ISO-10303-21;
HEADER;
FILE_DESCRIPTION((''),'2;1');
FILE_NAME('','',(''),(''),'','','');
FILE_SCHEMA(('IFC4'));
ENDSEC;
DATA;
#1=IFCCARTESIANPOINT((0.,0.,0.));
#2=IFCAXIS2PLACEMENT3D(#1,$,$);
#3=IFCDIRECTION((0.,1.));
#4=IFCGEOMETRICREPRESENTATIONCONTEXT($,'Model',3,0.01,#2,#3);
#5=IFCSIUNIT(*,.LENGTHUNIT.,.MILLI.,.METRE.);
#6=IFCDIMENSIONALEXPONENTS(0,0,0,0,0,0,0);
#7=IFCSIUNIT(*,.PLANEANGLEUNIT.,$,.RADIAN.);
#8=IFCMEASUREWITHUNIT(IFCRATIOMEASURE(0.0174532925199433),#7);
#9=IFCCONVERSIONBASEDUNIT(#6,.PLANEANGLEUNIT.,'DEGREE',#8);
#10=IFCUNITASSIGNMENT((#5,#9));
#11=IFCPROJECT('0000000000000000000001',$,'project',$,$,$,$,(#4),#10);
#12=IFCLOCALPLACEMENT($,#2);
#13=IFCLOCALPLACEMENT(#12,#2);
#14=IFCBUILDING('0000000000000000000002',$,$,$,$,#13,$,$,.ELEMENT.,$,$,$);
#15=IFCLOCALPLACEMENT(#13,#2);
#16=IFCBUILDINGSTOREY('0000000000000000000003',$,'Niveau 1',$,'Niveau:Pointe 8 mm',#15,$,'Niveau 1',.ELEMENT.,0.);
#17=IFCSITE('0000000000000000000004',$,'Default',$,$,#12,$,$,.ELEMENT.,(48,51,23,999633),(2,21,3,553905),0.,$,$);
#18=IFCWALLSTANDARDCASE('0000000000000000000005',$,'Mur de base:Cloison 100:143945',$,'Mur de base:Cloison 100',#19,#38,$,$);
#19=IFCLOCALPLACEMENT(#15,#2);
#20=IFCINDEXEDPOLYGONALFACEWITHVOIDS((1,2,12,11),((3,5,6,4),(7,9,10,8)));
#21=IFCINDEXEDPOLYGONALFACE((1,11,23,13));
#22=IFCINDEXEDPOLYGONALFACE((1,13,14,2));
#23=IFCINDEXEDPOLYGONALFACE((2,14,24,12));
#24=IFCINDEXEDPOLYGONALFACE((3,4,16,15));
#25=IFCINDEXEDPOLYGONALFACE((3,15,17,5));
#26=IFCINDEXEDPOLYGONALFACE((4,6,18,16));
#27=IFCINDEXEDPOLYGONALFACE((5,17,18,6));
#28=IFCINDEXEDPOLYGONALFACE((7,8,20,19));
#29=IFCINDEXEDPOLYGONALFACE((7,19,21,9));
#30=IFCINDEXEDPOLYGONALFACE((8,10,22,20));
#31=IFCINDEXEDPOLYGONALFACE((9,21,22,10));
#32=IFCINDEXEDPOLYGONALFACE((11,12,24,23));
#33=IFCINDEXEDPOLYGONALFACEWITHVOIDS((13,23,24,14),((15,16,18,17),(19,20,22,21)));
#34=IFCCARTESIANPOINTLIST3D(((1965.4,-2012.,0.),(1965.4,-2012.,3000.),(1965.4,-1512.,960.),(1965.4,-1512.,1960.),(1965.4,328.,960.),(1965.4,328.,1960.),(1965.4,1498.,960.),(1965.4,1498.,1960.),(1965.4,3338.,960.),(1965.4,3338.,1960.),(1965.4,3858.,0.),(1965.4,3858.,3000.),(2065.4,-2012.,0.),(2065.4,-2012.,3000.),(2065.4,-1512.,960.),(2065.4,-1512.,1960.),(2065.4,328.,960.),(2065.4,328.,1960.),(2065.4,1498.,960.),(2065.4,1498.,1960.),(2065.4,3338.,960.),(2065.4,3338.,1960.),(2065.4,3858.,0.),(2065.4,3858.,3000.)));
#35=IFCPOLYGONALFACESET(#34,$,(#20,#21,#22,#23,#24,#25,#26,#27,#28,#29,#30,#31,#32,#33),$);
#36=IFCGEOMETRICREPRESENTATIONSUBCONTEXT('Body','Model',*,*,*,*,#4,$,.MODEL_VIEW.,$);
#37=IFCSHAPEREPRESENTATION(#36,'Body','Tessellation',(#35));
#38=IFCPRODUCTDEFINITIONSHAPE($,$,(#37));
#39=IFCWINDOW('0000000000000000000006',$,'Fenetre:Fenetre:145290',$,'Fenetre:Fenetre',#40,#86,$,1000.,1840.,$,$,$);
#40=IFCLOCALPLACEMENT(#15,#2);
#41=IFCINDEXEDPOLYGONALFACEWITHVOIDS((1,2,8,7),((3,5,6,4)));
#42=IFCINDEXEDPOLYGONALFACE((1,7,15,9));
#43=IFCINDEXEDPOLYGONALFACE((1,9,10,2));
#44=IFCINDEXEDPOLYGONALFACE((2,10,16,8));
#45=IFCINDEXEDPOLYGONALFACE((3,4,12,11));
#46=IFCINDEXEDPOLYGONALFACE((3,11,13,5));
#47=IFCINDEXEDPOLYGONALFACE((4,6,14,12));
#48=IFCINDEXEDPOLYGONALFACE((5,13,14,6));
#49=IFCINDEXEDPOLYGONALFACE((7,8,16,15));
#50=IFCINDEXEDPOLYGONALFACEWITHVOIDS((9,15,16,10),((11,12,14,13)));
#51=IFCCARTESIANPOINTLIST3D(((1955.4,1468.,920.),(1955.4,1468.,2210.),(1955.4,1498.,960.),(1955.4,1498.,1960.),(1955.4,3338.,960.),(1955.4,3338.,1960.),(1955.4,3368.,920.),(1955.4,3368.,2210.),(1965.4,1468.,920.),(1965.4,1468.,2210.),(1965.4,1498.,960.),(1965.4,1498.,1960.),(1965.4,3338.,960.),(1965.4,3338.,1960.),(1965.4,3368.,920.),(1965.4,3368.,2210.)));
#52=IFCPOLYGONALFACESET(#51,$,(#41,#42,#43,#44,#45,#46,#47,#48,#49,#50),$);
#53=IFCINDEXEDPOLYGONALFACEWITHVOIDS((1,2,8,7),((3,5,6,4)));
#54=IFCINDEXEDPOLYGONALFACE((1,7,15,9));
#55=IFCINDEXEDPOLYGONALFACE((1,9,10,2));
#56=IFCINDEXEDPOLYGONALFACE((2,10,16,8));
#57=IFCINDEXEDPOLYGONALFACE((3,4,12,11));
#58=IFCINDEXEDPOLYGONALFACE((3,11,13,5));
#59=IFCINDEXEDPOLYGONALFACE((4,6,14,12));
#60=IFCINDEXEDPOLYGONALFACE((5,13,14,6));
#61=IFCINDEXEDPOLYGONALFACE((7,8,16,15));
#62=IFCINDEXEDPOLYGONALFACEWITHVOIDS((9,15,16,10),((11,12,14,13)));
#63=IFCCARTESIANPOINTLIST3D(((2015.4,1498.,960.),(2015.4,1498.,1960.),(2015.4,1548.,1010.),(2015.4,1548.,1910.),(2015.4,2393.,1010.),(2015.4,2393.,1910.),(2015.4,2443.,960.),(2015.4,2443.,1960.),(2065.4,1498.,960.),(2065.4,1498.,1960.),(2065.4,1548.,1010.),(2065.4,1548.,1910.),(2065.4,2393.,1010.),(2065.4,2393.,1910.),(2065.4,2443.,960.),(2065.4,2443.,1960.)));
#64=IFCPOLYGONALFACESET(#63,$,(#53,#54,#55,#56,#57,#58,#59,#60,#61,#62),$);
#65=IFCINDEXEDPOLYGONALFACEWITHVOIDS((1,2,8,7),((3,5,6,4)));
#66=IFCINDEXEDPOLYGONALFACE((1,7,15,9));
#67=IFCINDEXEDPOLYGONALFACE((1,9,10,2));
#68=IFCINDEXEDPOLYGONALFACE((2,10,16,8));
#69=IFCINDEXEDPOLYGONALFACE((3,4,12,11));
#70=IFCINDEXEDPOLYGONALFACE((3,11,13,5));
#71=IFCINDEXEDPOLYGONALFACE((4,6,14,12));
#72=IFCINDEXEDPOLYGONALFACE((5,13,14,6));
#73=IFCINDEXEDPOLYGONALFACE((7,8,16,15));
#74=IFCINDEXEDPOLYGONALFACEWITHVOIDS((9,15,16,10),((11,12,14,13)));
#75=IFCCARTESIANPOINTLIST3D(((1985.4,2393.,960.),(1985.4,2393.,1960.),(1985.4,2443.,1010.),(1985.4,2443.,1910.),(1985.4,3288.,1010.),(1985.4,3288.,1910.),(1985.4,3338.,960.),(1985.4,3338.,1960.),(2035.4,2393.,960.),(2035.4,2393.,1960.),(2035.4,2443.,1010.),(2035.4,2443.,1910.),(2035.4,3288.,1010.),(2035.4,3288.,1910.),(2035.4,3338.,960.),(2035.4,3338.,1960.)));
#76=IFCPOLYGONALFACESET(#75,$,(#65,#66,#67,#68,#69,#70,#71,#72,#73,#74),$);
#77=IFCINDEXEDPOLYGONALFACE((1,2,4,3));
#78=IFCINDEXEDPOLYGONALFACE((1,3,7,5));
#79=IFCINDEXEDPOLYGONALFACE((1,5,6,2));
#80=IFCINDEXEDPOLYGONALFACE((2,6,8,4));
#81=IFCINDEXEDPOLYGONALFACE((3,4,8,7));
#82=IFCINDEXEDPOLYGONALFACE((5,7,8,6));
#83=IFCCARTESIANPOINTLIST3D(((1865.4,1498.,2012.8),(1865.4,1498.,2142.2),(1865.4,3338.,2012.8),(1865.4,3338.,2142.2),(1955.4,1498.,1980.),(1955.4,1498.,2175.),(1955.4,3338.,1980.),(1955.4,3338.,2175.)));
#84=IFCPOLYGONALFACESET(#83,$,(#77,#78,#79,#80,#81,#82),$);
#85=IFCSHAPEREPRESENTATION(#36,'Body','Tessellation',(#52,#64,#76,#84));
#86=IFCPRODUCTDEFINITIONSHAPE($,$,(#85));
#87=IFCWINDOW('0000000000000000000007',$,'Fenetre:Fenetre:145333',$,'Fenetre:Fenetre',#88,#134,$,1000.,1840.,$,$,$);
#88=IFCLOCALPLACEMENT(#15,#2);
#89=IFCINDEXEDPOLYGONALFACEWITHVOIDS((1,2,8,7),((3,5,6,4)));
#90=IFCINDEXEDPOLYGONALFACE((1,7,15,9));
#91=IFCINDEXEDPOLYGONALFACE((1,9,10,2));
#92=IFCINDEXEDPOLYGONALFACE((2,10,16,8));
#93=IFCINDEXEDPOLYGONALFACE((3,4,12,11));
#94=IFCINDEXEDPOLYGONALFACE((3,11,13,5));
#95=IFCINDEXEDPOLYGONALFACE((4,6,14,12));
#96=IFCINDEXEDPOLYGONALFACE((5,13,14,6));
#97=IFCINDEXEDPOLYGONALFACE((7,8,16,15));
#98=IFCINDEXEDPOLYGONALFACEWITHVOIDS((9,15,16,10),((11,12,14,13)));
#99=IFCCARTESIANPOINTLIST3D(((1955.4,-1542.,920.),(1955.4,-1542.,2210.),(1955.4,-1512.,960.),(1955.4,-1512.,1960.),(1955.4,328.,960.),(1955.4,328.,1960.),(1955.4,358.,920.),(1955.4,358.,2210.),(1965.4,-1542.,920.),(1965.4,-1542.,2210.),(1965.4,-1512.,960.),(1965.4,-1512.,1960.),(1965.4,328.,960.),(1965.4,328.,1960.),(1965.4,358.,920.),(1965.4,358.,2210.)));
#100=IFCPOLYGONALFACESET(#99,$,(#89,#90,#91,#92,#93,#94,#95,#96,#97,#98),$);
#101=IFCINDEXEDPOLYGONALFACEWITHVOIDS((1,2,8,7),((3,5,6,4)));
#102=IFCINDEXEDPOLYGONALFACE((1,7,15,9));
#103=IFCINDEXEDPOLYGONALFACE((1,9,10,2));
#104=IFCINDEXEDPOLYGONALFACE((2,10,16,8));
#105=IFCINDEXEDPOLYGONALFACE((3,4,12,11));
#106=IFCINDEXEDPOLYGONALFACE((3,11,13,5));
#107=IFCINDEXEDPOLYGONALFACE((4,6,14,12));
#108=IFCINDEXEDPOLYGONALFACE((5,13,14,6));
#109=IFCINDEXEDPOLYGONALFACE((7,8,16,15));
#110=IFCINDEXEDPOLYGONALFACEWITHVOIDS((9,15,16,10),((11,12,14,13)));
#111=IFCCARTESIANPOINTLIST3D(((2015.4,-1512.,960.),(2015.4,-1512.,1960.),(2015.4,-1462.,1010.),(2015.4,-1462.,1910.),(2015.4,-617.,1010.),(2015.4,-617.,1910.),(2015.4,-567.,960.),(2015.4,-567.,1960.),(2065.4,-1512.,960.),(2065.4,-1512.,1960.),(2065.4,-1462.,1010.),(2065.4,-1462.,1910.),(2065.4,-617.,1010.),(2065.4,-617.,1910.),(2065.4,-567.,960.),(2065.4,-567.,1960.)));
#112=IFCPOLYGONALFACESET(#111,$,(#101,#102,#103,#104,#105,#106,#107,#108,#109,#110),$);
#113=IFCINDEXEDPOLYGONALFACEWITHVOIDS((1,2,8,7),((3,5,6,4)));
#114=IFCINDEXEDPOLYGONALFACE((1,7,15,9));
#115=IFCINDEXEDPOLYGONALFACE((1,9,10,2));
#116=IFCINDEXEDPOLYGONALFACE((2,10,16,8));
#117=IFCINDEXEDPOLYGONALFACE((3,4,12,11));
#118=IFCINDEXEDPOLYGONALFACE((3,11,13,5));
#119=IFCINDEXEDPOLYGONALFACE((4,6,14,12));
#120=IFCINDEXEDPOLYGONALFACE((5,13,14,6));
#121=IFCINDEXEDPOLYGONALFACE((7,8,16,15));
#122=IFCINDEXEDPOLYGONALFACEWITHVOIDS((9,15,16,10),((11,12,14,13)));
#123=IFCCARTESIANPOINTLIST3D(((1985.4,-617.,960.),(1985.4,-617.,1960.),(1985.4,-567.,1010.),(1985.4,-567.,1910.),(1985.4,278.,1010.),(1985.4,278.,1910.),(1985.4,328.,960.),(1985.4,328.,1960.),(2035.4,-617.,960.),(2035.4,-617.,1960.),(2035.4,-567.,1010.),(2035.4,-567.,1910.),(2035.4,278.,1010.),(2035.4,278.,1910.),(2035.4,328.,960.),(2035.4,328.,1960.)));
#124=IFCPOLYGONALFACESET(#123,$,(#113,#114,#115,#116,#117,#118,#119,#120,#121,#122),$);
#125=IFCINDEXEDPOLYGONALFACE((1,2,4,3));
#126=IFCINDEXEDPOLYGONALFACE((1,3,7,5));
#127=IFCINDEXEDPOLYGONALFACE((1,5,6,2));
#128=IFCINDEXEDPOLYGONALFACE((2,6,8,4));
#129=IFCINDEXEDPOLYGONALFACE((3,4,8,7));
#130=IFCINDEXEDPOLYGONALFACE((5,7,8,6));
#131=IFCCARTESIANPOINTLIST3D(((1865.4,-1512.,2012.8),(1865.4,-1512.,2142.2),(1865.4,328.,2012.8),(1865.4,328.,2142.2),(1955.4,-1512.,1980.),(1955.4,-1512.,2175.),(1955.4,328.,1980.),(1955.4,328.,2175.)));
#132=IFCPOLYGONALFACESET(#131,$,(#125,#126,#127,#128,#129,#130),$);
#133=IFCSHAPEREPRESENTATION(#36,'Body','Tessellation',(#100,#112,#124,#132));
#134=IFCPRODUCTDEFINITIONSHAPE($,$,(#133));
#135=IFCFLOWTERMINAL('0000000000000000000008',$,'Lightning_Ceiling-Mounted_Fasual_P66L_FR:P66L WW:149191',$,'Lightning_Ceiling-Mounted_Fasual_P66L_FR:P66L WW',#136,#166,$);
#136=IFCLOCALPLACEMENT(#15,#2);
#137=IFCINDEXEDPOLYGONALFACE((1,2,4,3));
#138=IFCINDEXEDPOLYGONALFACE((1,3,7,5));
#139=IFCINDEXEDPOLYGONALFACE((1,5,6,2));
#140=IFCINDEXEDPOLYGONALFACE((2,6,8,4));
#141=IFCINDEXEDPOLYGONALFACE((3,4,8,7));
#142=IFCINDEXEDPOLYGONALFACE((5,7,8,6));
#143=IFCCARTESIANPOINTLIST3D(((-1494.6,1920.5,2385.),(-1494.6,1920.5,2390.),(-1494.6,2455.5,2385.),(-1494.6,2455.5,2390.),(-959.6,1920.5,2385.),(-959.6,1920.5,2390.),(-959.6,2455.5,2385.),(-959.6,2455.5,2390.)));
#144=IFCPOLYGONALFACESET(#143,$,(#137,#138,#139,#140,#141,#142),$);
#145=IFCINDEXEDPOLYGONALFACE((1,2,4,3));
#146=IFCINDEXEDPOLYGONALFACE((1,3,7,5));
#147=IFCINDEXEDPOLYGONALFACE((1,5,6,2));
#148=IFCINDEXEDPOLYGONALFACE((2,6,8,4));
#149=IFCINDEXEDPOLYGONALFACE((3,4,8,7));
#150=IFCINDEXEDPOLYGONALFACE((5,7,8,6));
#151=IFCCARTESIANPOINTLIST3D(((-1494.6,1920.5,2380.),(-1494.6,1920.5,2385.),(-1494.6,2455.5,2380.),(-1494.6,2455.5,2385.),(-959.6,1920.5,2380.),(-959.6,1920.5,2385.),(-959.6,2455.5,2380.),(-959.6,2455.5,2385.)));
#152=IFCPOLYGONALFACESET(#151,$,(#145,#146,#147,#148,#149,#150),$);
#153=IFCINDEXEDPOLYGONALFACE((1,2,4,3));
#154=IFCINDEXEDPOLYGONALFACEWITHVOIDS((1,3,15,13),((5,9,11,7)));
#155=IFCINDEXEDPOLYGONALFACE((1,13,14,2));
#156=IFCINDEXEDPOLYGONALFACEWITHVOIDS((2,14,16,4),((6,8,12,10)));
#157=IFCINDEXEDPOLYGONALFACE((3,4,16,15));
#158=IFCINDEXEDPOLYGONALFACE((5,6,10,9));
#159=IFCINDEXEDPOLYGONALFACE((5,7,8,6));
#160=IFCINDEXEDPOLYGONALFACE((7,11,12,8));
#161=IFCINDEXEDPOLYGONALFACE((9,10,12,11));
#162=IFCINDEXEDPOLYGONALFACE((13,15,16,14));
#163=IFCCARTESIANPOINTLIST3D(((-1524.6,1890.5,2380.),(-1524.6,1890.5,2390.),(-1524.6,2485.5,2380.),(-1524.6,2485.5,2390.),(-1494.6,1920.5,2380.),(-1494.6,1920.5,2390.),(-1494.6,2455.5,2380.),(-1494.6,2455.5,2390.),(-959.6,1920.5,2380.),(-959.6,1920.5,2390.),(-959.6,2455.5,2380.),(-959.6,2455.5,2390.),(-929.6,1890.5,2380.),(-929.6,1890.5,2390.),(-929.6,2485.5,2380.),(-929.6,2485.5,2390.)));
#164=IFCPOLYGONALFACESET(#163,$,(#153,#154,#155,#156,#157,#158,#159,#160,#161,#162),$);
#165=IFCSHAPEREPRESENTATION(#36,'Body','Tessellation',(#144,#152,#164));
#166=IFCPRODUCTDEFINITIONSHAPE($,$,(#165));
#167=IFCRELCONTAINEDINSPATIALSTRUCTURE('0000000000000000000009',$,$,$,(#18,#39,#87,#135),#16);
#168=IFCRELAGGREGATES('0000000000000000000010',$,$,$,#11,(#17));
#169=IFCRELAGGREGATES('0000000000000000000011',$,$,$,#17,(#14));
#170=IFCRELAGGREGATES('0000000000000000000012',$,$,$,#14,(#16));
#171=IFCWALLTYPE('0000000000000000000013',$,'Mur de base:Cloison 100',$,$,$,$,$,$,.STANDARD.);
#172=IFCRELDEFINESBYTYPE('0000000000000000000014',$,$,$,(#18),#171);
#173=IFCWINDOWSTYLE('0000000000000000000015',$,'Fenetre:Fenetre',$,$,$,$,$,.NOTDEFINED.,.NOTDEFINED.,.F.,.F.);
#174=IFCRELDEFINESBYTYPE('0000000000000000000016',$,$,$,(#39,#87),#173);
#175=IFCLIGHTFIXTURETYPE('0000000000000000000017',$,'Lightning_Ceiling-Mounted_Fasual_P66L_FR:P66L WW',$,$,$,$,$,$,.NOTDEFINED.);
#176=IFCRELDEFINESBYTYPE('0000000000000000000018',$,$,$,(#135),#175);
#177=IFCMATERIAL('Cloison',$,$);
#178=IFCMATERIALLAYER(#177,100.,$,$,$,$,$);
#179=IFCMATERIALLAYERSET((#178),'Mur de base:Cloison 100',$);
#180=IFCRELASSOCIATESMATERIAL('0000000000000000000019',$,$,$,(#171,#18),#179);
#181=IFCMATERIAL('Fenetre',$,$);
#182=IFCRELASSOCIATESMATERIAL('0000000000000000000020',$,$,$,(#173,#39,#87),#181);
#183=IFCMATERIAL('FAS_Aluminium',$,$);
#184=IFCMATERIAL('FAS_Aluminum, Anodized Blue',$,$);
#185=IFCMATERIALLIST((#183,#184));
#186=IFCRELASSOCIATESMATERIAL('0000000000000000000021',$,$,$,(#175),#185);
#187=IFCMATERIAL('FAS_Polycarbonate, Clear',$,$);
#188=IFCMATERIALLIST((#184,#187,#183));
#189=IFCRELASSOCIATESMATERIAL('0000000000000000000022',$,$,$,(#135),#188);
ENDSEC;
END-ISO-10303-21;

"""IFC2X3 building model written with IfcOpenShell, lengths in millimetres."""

from ifc_helpers import new_model, entity, si_unit, converted_unit, direction, frame, frame_2d, origin, origin_2d_with_axis, place, context, subcontext, project, spatial, polyline, rectangle, outline, extrude, source, transform, mapped, material, material_list, layer, layer_set, layer_usage, type_object, type_shapes, element, fill, save


model = new_model("IFC2X3")

# Units and contexts
model_context = context("Model", 3, precision=0.01, world=origin(), true_north=direction((0.0, 1.0)))
body_context = subcontext(model_context, "Body", "Model", "MODEL_VIEW")
ifc_project = project(units=[si_unit("LENGTHUNIT", "METRE", prefix="MILLI"), converted_unit("PLANEANGLEUNIT", "DEGREE", entity("IfcRatioMeasure", 0.0174532925199433), si_unit("PLANEANGLEUNIT", "RADIAN"), dimensions=[0, 0, 0, 0, 0, 0, 0])], contexts=[model_context])

# Site, building, storey
site_placement = place(None, origin())
site = spatial("IfcSite", under=ifc_project, at=site_placement, Name="Default", CompositionType="ELEMENT", RefLatitude=(48, 51, 23, 999633), RefLongitude=(2, 21, 3, 553905), RefElevation=0.0)
building_placement = place(site_placement, origin())
building = spatial("IfcBuilding", under=site, at=building_placement, CompositionType="ELEMENT")
storey_placement = place(building_placement, origin())
storey = spatial("IfcBuildingStorey", under=building, at=storey_placement, Name="Niveau 1", ObjectType="Niveau:Pointe 8 mm", LongName="Niveau 1", CompositionType="ELEMENT", Elevation=0.0)

# Shared definitions
ifc_material_1 = material(Name="Cloison")
ifc_layer_1 = layer(ifc_material_1, 100.0)
ifc_layer_set_1 = layer_set([ifc_layer_1], Name="Mur de base:Cloison 100")
wall_type = type_object("IfcWallType", Name="Mur de base:Cloison 100", PredefinedType="STANDARD", material=ifc_layer_set_1)

# Wall, openings, windows
ifc_layer_usage_1 = layer_usage(ifc_layer_set_1, "AXIS2", "NEGATIVE", 50.0)
wall_1_placement = place(storey_placement, frame((2015.4, 3858.0, 0.0), z_axis=(0.0, 0.0, 1.0), x_axis=(0.0, -1.0, 0.0)))
wall_1 = element("IfcWallStandardCase", 1, at=wall_1_placement, inside=storey, type_object=wall_type, material=ifc_layer_usage_1, Name="Mur de base:Cloison 100:143945", ObjectType="Mur de base:Cloison 100", context=body_context, shape_type="SweptSolid", body=[
    extrude(rectangle(XDim=5870.0, YDim=100.0, at=frame_2d((2935.0, 0.0), x_axis=(-1.0, 0.0))), origin(), (0.0, 0.0, 1.0), 3000.0),
])
opening_1_placement = place(wall_1_placement, frame((520.0, -50.0, 960.0)))
opening_1 = element("IfcOpeningElement", 2, at=opening_1_placement, cuts=wall_1, ObjectType="Opening", context=body_context, shape_type="SweptSolid", body=[
    extrude(rectangle(XDim=1000.0, YDim=1840.0, at=frame_2d((500.0, 920.0), x_axis=(1.0, 0.0))), frame((0.0, 0.0, 0.0), z_axis=(0.0, 1.0, 0.0), x_axis=(0.0, 0.0, 1.0)), (0.0, 0.0, 1.0), 100.0),
])
opening_2_placement = place(wall_1_placement, frame((3530.0, -50.0, 960.0)))
opening_2 = element("IfcOpeningElement", 3, at=opening_2_placement, cuts=wall_1, ObjectType="Opening", context=body_context, shape_type="SweptSolid", body=[
    extrude(rectangle(XDim=1000.0, YDim=1840.0, at=frame_2d((500.0, 920.0), x_axis=(1.0, 0.0))), frame((0.0, 0.0, 0.0), z_axis=(0.0, 1.0, 0.0), x_axis=(0.0, 0.0, 1.0)), (0.0, 0.0, 1.0), 100.0),
])
ifc_material_2 = material(Name="Fenetre")
window_style = type_object("IfcWindowStyle", Name="Fenetre:Fenetre", ConstructionType="NOTDEFINED", OperationType="NOTDEFINED", ParameterTakesPrecedence=False, Sizeable=False, material=ifc_material_2)
shared_shape_1 = source(origin(), body_context, "Body", "SweptSolid", [
    extrude(outline(polyline([(-645.0, -950.0), (645.0, -950.0), (645.0, 950.0), (-645.0, 950.0), (-645.0, -950.0)]), holes=[polyline([(-395.0, -920.0), (-395.0, 920.0), (605.0, 920.0), (605.0, -920.0), (-395.0, -920.0)])]), frame((920.0, -10.0, 605.0), z_axis=(0.0, 1.0, 0.0), x_axis=(0.0, 0.0, -1.0)), (0.0, 0.0, 1.0), 10.0),
    extrude(outline(polyline([(-472.5, -500.0), (472.5, -500.0), (472.5, 500.0), (-472.5, 500.0), (-472.5, -500.0)]), holes=[polyline([(422.5, -450.0), (-422.5, -450.0), (-422.5, 450.0), (422.5, 450.0), (422.5, -450.0)])]), frame((1367.5, 50.0, 500.0), z_axis=(0.0, 1.0, 0.0), x_axis=(1.0, 0.0, 0.0)), (0.0, 0.0, 1.0), 50.0),
    extrude(outline(polyline([(-472.5, -500.0), (472.5, -500.0), (472.5, 500.0), (-472.5, 500.0), (-472.5, -500.0)]), holes=[polyline([(422.5, -450.0), (-422.5, -450.0), (-422.5, 450.0), (422.5, 450.0), (422.5, -450.0)])]), frame((472.5, 20.0, 500.0), z_axis=(0.0, 1.0, 0.0), x_axis=(1.0, 0.0, 0.0)), (0.0, 0.0, 1.0), 50.0),
    extrude(outline(polyline([(-97.5, -45.0), (97.5, -45.0), (64.7, 45.0), (-64.7, 45.0), (-97.5, -45.0)])), frame((0.0, -55.0, 1117.5), z_axis=(1.0, 0.0, 0.0), x_axis=(0.0, 0.0, 1.0)), (0.0, 0.0, 1.0), 1840.0),
])
type_shapes(window_style, [shared_shape_1])
window_1_placement = place(opening_1_placement, origin())
window_1 = element("IfcWindow", 4, at=window_1_placement, inside=storey, type_object=window_style, material=ifc_material_2, Name="Fenetre:Fenetre:145290", ObjectType="Fenetre:Fenetre", OverallHeight=1000.0, OverallWidth=1840.0, context=body_context, shape_type="MappedRepresentation", body=[
    mapped(shared_shape_1, transform((0.0, 0.0, 0.0), scale=1.0)),
])
fill(opening_1, window_1)
window_2_placement = place(opening_2_placement, origin())
window_2 = element("IfcWindow", 5, at=window_2_placement, inside=storey, type_object=window_style, material=ifc_material_2, Name="Fenetre:Fenetre:145333", ObjectType="Fenetre:Fenetre", OverallHeight=1000.0, OverallWidth=1840.0, context=body_context, shape_type="MappedRepresentation", body=[
    mapped(shared_shape_1, transform((0.0, 0.0, 0.0), scale=1.0)),
])
fill(opening_2, window_2)

# Flow terminal
ifc_material_3 = material(Name="FAS_Aluminum, Anodized Blue")
ifc_material_4 = material(Name="FAS_Polycarbonate, Clear")
ifc_material_5 = material(Name="FAS_Aluminium")
ifc_material_list_1 = material_list([ifc_material_3, ifc_material_4, ifc_material_5])
ifc_material_list_2 = material_list([ifc_material_5, ifc_material_3])
light_fixture_type = type_object("IfcLightFixtureType", Name="Lightning_Ceiling-Mounted_Fasual_P66L_FR:P66L WW", PredefinedType="NOTDEFINED", material=ifc_material_list_2)
shared_shape_2 = source(origin(), body_context, "Body", "SweptSolid", [
    extrude(rectangle(XDim=535.0, YDim=535.0, at=origin_2d_with_axis()), frame((0.0, 0.0, -10.0), z_axis=(0.0, 0.0, 1.0), x_axis=(0.0, 1.0, 0.0)), (0.0, 0.0, 1.0), 5.0),
    extrude(rectangle(XDim=535.0, YDim=535.0, at=origin_2d_with_axis()), frame((0.0, 0.0, -5.0), z_axis=(0.0, 0.0, 1.0), x_axis=(0.0, -1.0, 0.0)), (0.0, 0.0, 1.0), 5.0),
    extrude(outline(polyline([(-297.5, -297.5), (297.5, -297.5), (297.5, 297.5), (-297.5, 297.5), (-297.5, -297.5)]), holes=[polyline([(267.5, -267.5), (-267.5, -267.5), (-267.5, 267.5), (267.5, 267.5), (267.5, -267.5)])]), frame((0.0, 0.0, -10.0), z_axis=(0.0, 0.0, 1.0), x_axis=(0.0, 1.0, 0.0)), (0.0, 0.0, 1.0), 10.0),
])
type_shapes(light_fixture_type, [shared_shape_2])
flow_terminal_1_placement = place(storey_placement, frame((-1227.1, 2188.0, 2380.0), z_axis=(0.0, 0.0, -1.0), x_axis=(1.0, 0.0, 0.0)))
element("IfcFlowTerminal", 6, at=flow_terminal_1_placement, inside=storey, type_object=light_fixture_type, material=ifc_material_list_1, Name="Lightning_Ceiling-Mounted_Fasual_P66L_FR:P66L WW:149191", ObjectType="Lightning_Ceiling-Mounted_Fasual_P66L_FR:P66L WW", context=body_context, shape_type="MappedRepresentation", body=[
    mapped(shared_shape_2, transform((0.0, 0.0, 0.0), scale=1.0)),
])

save(model, "model.ifc")
